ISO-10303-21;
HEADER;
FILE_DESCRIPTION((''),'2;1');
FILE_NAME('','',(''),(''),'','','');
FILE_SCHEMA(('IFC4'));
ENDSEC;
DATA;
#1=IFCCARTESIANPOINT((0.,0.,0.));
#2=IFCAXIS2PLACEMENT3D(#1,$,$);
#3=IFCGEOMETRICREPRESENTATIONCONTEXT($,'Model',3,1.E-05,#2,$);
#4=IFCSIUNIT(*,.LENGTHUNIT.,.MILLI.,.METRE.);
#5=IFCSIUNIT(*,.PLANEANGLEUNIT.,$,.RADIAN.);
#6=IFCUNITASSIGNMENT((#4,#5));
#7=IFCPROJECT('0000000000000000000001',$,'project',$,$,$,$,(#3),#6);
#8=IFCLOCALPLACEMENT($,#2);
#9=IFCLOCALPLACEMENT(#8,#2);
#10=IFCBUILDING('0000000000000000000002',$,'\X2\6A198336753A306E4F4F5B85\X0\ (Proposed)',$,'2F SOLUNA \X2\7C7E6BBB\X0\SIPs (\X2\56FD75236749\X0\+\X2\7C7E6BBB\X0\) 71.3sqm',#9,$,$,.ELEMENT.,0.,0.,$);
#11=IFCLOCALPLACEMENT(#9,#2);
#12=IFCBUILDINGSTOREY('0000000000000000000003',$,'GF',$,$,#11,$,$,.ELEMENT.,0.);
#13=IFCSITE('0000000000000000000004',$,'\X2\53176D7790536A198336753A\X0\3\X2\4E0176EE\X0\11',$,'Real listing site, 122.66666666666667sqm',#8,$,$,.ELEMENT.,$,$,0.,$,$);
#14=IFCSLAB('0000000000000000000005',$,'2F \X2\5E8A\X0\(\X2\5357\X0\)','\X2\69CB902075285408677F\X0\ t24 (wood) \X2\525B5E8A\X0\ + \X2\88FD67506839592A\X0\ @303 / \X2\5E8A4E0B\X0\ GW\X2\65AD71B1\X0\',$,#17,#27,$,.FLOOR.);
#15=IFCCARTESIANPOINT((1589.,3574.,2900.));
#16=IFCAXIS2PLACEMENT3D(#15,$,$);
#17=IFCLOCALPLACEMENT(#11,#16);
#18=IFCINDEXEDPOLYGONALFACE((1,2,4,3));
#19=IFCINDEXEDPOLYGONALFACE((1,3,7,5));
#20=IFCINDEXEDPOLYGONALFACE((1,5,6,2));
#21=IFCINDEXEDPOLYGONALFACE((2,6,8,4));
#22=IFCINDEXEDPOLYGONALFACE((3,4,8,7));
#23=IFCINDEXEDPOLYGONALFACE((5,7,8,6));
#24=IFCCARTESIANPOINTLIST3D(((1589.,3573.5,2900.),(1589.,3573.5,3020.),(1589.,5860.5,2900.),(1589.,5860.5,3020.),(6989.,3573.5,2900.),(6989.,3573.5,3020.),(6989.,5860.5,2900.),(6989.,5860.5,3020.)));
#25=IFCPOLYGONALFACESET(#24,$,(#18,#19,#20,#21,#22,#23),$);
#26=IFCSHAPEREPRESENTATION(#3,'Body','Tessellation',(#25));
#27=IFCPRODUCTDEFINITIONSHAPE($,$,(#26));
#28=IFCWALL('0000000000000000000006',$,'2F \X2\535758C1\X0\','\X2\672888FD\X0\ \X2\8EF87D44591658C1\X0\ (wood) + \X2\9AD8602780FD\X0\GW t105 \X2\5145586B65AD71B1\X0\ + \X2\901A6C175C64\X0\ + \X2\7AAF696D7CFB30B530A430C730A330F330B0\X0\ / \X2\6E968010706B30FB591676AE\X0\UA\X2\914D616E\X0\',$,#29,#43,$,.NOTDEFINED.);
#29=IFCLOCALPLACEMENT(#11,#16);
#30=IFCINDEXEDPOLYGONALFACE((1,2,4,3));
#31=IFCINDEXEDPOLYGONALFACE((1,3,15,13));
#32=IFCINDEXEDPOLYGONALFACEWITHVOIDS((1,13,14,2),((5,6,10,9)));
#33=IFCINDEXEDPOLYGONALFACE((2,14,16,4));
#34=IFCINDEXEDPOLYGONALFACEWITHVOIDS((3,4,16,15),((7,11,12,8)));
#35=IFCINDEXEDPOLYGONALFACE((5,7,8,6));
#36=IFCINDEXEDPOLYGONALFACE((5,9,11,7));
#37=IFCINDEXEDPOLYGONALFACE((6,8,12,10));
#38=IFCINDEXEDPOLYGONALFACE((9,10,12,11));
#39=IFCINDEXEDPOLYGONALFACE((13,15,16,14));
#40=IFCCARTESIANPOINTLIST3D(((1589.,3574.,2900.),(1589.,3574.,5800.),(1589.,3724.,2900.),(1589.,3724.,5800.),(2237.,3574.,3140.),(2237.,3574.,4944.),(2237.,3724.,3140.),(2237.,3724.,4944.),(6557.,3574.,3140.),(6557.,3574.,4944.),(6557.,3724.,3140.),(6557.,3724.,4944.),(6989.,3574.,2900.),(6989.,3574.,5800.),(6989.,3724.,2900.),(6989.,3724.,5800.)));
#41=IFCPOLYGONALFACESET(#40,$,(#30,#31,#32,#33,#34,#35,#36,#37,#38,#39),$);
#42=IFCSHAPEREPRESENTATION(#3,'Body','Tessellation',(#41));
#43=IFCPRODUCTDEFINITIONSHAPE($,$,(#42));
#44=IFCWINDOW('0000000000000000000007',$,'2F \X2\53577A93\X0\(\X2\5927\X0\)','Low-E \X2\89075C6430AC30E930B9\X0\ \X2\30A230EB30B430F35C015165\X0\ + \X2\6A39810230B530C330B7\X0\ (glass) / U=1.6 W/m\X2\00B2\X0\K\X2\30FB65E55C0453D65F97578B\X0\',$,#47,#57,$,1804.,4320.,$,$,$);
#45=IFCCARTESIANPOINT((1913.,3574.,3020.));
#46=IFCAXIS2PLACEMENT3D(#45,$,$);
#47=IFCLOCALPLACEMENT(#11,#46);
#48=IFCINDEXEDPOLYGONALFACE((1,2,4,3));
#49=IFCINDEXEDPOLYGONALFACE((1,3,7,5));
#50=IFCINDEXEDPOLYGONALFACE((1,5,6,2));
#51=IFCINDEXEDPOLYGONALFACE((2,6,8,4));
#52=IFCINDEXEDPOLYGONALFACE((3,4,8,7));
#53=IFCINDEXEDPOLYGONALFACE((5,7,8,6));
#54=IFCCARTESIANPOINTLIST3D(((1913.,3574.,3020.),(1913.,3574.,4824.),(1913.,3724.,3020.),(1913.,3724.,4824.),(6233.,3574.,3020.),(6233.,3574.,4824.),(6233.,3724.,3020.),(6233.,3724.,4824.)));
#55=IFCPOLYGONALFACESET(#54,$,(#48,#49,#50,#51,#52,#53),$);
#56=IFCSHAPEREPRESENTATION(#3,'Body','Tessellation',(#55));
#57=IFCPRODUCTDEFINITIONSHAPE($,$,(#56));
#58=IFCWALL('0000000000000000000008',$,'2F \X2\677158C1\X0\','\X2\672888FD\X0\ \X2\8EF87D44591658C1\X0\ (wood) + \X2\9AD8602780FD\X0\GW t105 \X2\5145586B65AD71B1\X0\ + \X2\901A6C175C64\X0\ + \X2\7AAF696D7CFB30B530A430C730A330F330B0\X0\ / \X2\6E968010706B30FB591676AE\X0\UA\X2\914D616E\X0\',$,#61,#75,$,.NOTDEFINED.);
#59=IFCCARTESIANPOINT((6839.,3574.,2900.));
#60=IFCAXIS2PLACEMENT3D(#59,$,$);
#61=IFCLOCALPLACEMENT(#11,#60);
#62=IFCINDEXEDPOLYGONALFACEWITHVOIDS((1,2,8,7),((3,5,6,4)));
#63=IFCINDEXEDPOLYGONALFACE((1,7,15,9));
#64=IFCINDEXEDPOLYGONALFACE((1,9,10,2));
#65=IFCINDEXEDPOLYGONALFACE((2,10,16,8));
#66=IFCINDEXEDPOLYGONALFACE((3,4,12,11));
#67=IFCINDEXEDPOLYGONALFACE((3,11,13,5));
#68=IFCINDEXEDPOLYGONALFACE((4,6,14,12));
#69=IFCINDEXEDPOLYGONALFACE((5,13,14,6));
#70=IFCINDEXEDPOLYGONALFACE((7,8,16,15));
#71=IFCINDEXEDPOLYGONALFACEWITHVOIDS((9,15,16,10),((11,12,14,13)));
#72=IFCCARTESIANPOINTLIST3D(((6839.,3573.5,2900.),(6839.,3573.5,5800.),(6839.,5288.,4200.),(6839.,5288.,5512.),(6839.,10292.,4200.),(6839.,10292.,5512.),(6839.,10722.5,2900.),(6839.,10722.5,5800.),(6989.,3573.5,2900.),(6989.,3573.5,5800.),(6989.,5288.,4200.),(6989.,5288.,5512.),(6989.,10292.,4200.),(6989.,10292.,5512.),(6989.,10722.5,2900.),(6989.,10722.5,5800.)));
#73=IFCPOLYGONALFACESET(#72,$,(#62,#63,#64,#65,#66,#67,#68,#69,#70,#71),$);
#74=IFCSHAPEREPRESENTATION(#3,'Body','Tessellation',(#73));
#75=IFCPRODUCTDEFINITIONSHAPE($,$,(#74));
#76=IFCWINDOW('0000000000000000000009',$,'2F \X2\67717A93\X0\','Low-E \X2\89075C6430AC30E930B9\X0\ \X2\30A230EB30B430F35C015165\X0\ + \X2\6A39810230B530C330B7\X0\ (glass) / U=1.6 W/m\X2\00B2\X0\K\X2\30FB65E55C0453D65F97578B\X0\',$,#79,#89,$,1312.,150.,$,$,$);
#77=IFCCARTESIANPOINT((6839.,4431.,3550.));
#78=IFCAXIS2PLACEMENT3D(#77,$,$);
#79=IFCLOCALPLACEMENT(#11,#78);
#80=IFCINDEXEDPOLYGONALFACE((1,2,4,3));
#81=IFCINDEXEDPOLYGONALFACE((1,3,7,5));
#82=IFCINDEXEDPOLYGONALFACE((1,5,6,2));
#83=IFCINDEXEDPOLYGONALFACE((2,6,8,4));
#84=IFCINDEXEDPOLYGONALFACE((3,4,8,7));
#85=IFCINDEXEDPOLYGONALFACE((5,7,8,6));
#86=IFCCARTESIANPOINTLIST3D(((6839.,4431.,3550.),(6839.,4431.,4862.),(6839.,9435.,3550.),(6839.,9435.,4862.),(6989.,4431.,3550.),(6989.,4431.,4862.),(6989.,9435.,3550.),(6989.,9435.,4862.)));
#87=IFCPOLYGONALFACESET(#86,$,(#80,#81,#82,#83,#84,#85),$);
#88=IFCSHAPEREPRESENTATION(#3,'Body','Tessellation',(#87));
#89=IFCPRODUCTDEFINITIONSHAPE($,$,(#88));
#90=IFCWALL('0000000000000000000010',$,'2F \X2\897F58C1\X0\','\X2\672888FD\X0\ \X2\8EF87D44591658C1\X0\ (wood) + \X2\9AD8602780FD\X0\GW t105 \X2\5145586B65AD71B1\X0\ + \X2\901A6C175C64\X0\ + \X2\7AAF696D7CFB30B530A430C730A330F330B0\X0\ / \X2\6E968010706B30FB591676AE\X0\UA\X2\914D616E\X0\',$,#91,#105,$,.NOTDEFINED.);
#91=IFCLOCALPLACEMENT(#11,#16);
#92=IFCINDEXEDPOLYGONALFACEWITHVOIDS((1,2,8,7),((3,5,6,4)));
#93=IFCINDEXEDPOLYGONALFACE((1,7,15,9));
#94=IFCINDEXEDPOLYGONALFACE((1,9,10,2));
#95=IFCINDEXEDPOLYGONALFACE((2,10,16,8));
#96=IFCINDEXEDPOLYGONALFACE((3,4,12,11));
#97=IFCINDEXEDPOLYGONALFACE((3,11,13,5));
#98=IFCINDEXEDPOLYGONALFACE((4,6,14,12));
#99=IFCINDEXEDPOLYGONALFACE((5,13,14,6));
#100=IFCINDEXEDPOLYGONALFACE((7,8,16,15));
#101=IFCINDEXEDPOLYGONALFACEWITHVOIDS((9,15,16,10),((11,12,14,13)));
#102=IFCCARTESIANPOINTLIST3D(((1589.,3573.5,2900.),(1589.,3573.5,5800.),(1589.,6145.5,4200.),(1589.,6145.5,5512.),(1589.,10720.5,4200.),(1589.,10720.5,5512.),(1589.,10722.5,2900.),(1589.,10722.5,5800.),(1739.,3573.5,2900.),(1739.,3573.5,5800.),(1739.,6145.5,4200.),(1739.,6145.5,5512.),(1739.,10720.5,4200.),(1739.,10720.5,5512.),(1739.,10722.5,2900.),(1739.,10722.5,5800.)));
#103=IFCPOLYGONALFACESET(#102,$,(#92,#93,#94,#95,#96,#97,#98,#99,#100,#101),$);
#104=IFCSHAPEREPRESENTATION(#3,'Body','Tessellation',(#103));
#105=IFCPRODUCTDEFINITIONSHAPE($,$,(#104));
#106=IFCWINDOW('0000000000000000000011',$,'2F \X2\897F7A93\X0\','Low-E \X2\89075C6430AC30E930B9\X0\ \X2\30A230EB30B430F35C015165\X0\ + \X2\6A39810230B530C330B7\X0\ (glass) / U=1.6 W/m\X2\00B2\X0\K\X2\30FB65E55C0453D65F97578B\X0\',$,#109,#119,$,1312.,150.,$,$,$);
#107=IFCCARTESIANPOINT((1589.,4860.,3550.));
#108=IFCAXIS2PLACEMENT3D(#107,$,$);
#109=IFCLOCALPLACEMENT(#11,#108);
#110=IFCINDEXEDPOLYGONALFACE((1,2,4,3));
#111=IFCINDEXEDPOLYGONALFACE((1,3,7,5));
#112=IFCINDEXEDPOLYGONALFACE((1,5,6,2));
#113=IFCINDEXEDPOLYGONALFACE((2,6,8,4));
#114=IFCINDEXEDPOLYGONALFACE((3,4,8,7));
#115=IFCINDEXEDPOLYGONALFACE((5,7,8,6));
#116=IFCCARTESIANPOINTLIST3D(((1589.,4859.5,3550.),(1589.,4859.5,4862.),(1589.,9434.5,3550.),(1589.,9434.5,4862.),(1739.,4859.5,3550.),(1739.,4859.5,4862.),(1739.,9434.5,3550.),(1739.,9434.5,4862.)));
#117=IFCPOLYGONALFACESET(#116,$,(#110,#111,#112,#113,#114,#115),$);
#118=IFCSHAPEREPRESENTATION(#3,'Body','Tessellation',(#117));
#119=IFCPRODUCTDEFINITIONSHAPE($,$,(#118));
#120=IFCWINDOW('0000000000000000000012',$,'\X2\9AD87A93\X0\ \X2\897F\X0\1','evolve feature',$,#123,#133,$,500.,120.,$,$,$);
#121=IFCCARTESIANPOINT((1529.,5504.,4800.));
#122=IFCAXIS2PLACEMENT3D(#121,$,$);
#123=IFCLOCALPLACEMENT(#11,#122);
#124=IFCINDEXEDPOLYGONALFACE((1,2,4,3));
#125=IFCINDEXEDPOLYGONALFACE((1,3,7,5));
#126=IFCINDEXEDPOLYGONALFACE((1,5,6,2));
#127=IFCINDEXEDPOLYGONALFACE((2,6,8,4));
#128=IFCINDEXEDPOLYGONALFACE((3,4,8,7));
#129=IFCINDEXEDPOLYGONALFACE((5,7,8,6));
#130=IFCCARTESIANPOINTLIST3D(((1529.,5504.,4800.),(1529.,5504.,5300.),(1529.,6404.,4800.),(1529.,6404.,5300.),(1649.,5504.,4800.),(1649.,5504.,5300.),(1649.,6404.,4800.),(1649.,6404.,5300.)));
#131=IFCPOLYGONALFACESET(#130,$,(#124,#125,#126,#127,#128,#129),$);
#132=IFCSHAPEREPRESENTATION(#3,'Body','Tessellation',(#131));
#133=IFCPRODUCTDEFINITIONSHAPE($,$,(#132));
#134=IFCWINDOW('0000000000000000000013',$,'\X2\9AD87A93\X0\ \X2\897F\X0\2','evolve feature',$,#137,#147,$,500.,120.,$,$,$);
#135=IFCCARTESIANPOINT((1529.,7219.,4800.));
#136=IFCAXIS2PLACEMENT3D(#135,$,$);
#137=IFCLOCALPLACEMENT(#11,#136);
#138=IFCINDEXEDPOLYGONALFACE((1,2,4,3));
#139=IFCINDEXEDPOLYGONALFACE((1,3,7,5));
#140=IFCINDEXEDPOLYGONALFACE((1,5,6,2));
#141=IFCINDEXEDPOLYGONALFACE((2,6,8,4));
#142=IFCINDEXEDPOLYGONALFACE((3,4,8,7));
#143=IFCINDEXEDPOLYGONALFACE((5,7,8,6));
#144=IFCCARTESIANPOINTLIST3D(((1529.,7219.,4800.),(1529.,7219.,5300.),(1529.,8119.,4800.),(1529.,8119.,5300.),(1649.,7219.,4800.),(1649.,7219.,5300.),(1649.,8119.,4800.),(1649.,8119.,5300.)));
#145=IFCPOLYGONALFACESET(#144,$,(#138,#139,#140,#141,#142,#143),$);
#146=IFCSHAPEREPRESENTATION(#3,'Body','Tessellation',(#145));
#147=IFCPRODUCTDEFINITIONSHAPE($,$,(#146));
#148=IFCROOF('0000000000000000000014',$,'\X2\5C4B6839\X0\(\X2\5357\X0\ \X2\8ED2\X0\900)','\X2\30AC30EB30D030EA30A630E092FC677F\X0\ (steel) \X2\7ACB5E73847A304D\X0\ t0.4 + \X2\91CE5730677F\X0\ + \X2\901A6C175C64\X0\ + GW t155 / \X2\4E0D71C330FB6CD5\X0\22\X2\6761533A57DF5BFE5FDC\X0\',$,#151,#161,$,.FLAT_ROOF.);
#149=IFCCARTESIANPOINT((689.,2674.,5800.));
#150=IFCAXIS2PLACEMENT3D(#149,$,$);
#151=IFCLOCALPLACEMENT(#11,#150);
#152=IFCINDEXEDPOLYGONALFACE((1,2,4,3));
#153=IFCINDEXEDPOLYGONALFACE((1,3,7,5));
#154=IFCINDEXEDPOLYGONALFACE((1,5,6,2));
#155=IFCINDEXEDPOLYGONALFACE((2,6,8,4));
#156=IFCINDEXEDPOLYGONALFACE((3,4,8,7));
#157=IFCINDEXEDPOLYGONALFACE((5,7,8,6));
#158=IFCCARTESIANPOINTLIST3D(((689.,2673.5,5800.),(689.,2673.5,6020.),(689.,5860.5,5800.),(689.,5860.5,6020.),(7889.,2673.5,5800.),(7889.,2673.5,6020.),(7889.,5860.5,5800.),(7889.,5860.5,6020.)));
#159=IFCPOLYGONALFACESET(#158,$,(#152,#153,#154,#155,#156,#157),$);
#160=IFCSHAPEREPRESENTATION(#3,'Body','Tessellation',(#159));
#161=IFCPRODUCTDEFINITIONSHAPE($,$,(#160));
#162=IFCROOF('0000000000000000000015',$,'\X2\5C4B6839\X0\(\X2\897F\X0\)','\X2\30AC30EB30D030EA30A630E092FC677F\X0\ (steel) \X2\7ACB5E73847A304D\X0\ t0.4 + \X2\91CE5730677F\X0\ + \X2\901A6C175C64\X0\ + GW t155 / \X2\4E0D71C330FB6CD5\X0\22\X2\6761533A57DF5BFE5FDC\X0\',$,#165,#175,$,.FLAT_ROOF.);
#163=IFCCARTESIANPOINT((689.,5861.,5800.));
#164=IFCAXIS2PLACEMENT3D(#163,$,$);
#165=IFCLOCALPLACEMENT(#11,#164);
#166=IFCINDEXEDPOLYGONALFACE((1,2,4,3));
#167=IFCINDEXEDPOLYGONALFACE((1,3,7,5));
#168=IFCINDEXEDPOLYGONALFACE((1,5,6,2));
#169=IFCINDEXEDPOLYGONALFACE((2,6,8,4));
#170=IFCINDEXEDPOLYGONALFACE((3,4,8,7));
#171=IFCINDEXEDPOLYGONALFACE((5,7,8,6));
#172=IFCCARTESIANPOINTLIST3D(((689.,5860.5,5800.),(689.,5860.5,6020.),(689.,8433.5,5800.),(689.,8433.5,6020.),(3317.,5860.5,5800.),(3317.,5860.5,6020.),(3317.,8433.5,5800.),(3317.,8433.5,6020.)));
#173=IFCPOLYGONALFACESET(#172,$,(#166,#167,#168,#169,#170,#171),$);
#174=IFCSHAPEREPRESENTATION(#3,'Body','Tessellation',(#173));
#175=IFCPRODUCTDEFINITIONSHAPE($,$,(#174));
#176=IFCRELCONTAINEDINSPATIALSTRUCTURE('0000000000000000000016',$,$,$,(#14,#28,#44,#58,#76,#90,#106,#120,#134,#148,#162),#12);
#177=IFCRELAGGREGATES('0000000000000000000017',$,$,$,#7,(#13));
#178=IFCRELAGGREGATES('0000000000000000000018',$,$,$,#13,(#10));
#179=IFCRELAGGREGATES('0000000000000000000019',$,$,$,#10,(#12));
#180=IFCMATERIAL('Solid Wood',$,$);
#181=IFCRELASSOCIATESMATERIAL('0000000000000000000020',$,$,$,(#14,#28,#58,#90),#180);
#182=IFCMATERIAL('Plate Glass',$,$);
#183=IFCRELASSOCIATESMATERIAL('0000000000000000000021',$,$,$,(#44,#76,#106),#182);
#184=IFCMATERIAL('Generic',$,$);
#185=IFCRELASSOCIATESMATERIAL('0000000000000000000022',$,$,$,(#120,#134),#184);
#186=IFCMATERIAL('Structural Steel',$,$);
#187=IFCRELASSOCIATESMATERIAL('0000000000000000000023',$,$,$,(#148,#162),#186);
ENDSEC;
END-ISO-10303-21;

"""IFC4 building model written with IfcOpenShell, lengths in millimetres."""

from ifc_helpers import new_model, si_unit, frame, frame_2d, origin, place, context, project, spatial, rectangle, extrude, material, element, fill, save


model = new_model("IFC4")

# Units and contexts
model_context = context("Model", 3, precision=1e-05, world=origin())
ifc_project = project(units=[si_unit("LENGTHUNIT", "METRE", prefix="MILLI"), si_unit("PLANEANGLEUNIT", "RADIAN")], contexts=[model_context])

# Site, building, storey
site_placement = place(None, origin())
site = spatial("IfcSite", under=ifc_project, at=site_placement, Name="北海道標茶町3丁目11", ObjectType="Real listing site, 122.66666666666667sqm", CompositionType="ELEMENT", RefElevation=0.0)
building_placement = place(site_placement, origin())
building = spatial("IfcBuilding", under=site, at=building_placement, Name="標茶町の住宅 (Proposed)", ObjectType="2F SOLUNA 籾殻SIPs (国産杉+籾殻) 71.3sqm", CompositionType="ELEMENT", ElevationOfRefHeight=0.0, ElevationOfTerrain=0.0)
storey_placement = place(building_placement, origin())
storey = spatial("IfcBuildingStorey", under=building, at=storey_placement, Name="GF", CompositionType="ELEMENT", Elevation=0.0)

# Slab
ifc_material_1 = material(Name="Solid Wood")
slab_placement = place(storey_placement, frame((1589.0, 3574.0, 2900.0)))
element("IfcSlab", 1, at=slab_placement, inside=storey, material=ifc_material_1, Name="2F 床(南)", Description="構造用合板 t24 (wood) 剛床 + 製材根太 @303 / 床下 GW断熱", PredefinedType="FLOOR", context=model_context, shape_type="SweptSolid", body=[
    extrude(rectangle(XDim=5400.0, YDim=2287.0, at=frame_2d((2700.0, 1143.0))), frame((1589.0, 3574.0, 2900.0)), (0.0, 0.0, 1.0), 120.0),
])

# Walls, openings, windows
wall_1_placement = place(storey_placement, frame((1589.0, 3574.0, 2900.0)))
wall_1 = element("IfcWall", 2, at=wall_1_placement, inside=storey, material=ifc_material_1, Name="2F 南壁", Description="木製 軸組外壁 (wood) + 高性能GW t105 充填断熱 + 通気層 + 窯業系サイディング / 準耐火・外皮UA配慮", PredefinedType="NOTDEFINED", context=model_context, shape_type="SweptSolid", body=[
    extrude(rectangle(XDim=5400.0, YDim=150.0, at=frame_2d((2700.0, 75.0))), frame((1589.0, 3574.0, 2900.0)), (0.0, 0.0, 1.0), 2900.0),
])
opening_1_placement = place(storey_placement, frame((1913.0, 3574.0, 3020.0)))
opening_1 = element("IfcOpeningElement", 3, at=opening_1_placement, cuts=wall_1, PredefinedType="NOTDEFINED", context=model_context, shape_type="SweptSolid", body=[
    extrude(rectangle(XDim=4320.0, YDim=150.0, at=frame_2d((2160.0, 75.0))), frame((1913.0, 3574.0, 3020.0)), (0.0, 0.0, 1.0), 1804.0),
])
ifc_material_2 = material(Name="Plate Glass")
window_1_placement = place(storey_placement, frame((1913.0, 3574.0, 3020.0)))
window_1 = element("IfcWindow", 4, at=window_1_placement, inside=storey, material=ifc_material_2, Name="2F 南窓(大)", Description="Low-E 複層ガラス アルゴン封入 + 樹脂サッシ (glass) / U=1.6 W/m²K・日射取得型", OverallHeight=1804.0, OverallWidth=4320.0, context=model_context, shape_type="SweptSolid", body=[
    extrude(rectangle(XDim=4320.0, YDim=150.0, at=frame_2d((2160.0, 75.0))), frame((1913.0, 3574.0, 3020.0)), (0.0, 0.0, 1.0), 1804.0),
])
fill(opening_1, window_1)
wall_2_placement = place(storey_placement, frame((6839.0, 3574.0, 2900.0)))
wall_2 = element("IfcWall", 5, at=wall_2_placement, inside=storey, material=ifc_material_1, Name="2F 東壁", Description="木製 軸組外壁 (wood) + 高性能GW t105 充填断熱 + 通気層 + 窯業系サイディング / 準耐火・外皮UA配慮", PredefinedType="NOTDEFINED", context=model_context, shape_type="SweptSolid", body=[
    extrude(rectangle(XDim=150.0, YDim=7149.0, at=frame_2d((75.0, 3574.0))), frame((6839.0, 3574.0, 2900.0)), (0.0, 0.0, 1.0), 2900.0),
])
opening_2_placement = place(storey_placement, frame((6839.0, 4431.0, 3550.0)))
opening_2 = element("IfcOpeningElement", 6, at=opening_2_placement, cuts=wall_2, PredefinedType="NOTDEFINED", context=model_context, shape_type="SweptSolid", body=[
    extrude(rectangle(XDim=150.0, YDim=5004.0, at=frame_2d((75.0, 2502.0))), frame((6839.0, 4431.0, 3550.0)), (0.0, 0.0, 1.0), 1312.0),
])
window_2_placement = place(storey_placement, frame((6839.0, 4431.0, 3550.0)))
window_2 = element("IfcWindow", 7, at=window_2_placement, inside=storey, material=ifc_material_2, Name="2F 東窓", Description="Low-E 複層ガラス アルゴン封入 + 樹脂サッシ (glass) / U=1.6 W/m²K・日射取得型", OverallHeight=1312.0, OverallWidth=150.0, context=model_context, shape_type="SweptSolid", body=[
    extrude(rectangle(XDim=150.0, YDim=5004.0, at=frame_2d((75.0, 2502.0))), frame((6839.0, 4431.0, 3550.0)), (0.0, 0.0, 1.0), 1312.0),
])
fill(opening_2, window_2)

# Wall, openings, windows
wall_3_placement = place(storey_placement, frame((1589.0, 3574.0, 2900.0)))
wall_3 = element("IfcWall", 8, at=wall_3_placement, inside=storey, material=ifc_material_1, Name="2F 西壁", Description="木製 軸組外壁 (wood) + 高性能GW t105 充填断熱 + 通気層 + 窯業系サイディング / 準耐火・外皮UA配慮", PredefinedType="NOTDEFINED", context=model_context, shape_type="SweptSolid", body=[
    extrude(rectangle(XDim=150.0, YDim=7149.0, at=frame_2d((75.0, 3574.0))), frame((1589.0, 3574.0, 2900.0)), (0.0, 0.0, 1.0), 2900.0),
])
opening_3_placement = place(storey_placement, frame((1589.0, 4860.0, 3550.0)))
opening_3 = element("IfcOpeningElement", 9, at=opening_3_placement, cuts=wall_3, PredefinedType="NOTDEFINED", context=model_context, shape_type="SweptSolid", body=[
    extrude(rectangle(XDim=150.0, YDim=4575.0, at=frame_2d((75.0, 2287.0))), frame((1589.0, 4860.0, 3550.0)), (0.0, 0.0, 1.0), 1312.0),
])
opening_4_placement = place(storey_placement, frame((1529.0, 5504.0, 4800.0)))
opening_4 = element("IfcOpeningElement", 10, at=opening_4_placement, cuts=wall_3, PredefinedType="NOTDEFINED", context=model_context, shape_type="SweptSolid", body=[
    extrude(rectangle(XDim=120.0, YDim=900.0, at=frame_2d((60.0, 450.0))), frame((1529.0, 5504.0, 4800.0)), (0.0, 0.0, 1.0), 500.0),
])
opening_5_placement = place(storey_placement, frame((1529.0, 7219.0, 4800.0)))
opening_5 = element("IfcOpeningElement", 11, at=opening_5_placement, cuts=wall_3, PredefinedType="NOTDEFINED", context=model_context, shape_type="SweptSolid", body=[
    extrude(rectangle(XDim=120.0, YDim=900.0, at=frame_2d((60.0, 450.0))), frame((1529.0, 7219.0, 4800.0)), (0.0, 0.0, 1.0), 500.0),
])
window_3_placement = place(storey_placement, frame((1589.0, 4860.0, 3550.0)))
window_3 = element("IfcWindow", 12, at=window_3_placement, inside=storey, material=ifc_material_2, Name="2F 西窓", Description="Low-E 複層ガラス アルゴン封入 + 樹脂サッシ (glass) / U=1.6 W/m²K・日射取得型", OverallHeight=1312.0, OverallWidth=150.0, context=model_context, shape_type="SweptSolid", body=[
    extrude(rectangle(XDim=150.0, YDim=4575.0, at=frame_2d((75.0, 2287.0))), frame((1589.0, 4860.0, 3550.0)), (0.0, 0.0, 1.0), 1312.0),
])
fill(opening_3, window_3)
ifc_material_3 = material(Name="Generic")
window_4_placement = place(storey_placement, frame((1529.0, 5504.0, 4800.0)))
window_4 = element("IfcWindow", 13, at=window_4_placement, inside=storey, material=ifc_material_3, Name="高窓 西1", Description="evolve feature", OverallHeight=500.0, OverallWidth=120.0, context=model_context, shape_type="SweptSolid", body=[
    extrude(rectangle(XDim=120.0, YDim=900.0, at=frame_2d((60.0, 450.0))), frame((1529.0, 5504.0, 4800.0)), (0.0, 0.0, 1.0), 500.0),
])
fill(opening_4, window_4)
window_5_placement = place(storey_placement, frame((1529.0, 7219.0, 4800.0)))
window_5 = element("IfcWindow", 14, at=window_5_placement, inside=storey, material=ifc_material_3, Name="高窓 西2", Description="evolve feature", OverallHeight=500.0, OverallWidth=120.0, context=model_context, shape_type="SweptSolid", body=[
    extrude(rectangle(XDim=120.0, YDim=900.0, at=frame_2d((60.0, 450.0))), frame((1529.0, 7219.0, 4800.0)), (0.0, 0.0, 1.0), 500.0),
])
fill(opening_5, window_5)

# Roofs
ifc_material_4 = material(Name="Structural Steel")
roof_1_placement = place(storey_placement, frame((689.0, 2674.0, 5800.0)))
element("IfcRoof", 15, at=roof_1_placement, inside=storey, material=ifc_material_4, Name="屋根(南 軒900)", Description="ガルバリウム鋼板 (steel) 立平葺き t0.4 + 野地板 + 通気層 + GW t155 / 不燃・法22条区域対応", PredefinedType="FLAT_ROOF", context=model_context, shape_type="SweptSolid", body=[
    extrude(rectangle(XDim=7200.0, YDim=3187.0, at=frame_2d((3600.0, 1593.0))), frame((689.0, 2674.0, 5800.0)), (0.0, 0.0, 1.0), 220.0),
])
roof_2_placement = place(storey_placement, frame((689.0, 5861.0, 5800.0)))
element("IfcRoof", 16, at=roof_2_placement, inside=storey, material=ifc_material_4, Name="屋根(西)", Description="ガルバリウム鋼板 (steel) 立平葺き t0.4 + 野地板 + 通気層 + GW t155 / 不燃・法22条区域対応", PredefinedType="FLAT_ROOF", context=model_context, shape_type="SweptSolid", body=[
    extrude(rectangle(XDim=2628.0, YDim=2573.0, at=frame_2d((1314.0, 1286.0))), frame((689.0, 5861.0, 5800.0)), (0.0, 0.0, 1.0), 220.0),
])

save(model, "model.ifc")
